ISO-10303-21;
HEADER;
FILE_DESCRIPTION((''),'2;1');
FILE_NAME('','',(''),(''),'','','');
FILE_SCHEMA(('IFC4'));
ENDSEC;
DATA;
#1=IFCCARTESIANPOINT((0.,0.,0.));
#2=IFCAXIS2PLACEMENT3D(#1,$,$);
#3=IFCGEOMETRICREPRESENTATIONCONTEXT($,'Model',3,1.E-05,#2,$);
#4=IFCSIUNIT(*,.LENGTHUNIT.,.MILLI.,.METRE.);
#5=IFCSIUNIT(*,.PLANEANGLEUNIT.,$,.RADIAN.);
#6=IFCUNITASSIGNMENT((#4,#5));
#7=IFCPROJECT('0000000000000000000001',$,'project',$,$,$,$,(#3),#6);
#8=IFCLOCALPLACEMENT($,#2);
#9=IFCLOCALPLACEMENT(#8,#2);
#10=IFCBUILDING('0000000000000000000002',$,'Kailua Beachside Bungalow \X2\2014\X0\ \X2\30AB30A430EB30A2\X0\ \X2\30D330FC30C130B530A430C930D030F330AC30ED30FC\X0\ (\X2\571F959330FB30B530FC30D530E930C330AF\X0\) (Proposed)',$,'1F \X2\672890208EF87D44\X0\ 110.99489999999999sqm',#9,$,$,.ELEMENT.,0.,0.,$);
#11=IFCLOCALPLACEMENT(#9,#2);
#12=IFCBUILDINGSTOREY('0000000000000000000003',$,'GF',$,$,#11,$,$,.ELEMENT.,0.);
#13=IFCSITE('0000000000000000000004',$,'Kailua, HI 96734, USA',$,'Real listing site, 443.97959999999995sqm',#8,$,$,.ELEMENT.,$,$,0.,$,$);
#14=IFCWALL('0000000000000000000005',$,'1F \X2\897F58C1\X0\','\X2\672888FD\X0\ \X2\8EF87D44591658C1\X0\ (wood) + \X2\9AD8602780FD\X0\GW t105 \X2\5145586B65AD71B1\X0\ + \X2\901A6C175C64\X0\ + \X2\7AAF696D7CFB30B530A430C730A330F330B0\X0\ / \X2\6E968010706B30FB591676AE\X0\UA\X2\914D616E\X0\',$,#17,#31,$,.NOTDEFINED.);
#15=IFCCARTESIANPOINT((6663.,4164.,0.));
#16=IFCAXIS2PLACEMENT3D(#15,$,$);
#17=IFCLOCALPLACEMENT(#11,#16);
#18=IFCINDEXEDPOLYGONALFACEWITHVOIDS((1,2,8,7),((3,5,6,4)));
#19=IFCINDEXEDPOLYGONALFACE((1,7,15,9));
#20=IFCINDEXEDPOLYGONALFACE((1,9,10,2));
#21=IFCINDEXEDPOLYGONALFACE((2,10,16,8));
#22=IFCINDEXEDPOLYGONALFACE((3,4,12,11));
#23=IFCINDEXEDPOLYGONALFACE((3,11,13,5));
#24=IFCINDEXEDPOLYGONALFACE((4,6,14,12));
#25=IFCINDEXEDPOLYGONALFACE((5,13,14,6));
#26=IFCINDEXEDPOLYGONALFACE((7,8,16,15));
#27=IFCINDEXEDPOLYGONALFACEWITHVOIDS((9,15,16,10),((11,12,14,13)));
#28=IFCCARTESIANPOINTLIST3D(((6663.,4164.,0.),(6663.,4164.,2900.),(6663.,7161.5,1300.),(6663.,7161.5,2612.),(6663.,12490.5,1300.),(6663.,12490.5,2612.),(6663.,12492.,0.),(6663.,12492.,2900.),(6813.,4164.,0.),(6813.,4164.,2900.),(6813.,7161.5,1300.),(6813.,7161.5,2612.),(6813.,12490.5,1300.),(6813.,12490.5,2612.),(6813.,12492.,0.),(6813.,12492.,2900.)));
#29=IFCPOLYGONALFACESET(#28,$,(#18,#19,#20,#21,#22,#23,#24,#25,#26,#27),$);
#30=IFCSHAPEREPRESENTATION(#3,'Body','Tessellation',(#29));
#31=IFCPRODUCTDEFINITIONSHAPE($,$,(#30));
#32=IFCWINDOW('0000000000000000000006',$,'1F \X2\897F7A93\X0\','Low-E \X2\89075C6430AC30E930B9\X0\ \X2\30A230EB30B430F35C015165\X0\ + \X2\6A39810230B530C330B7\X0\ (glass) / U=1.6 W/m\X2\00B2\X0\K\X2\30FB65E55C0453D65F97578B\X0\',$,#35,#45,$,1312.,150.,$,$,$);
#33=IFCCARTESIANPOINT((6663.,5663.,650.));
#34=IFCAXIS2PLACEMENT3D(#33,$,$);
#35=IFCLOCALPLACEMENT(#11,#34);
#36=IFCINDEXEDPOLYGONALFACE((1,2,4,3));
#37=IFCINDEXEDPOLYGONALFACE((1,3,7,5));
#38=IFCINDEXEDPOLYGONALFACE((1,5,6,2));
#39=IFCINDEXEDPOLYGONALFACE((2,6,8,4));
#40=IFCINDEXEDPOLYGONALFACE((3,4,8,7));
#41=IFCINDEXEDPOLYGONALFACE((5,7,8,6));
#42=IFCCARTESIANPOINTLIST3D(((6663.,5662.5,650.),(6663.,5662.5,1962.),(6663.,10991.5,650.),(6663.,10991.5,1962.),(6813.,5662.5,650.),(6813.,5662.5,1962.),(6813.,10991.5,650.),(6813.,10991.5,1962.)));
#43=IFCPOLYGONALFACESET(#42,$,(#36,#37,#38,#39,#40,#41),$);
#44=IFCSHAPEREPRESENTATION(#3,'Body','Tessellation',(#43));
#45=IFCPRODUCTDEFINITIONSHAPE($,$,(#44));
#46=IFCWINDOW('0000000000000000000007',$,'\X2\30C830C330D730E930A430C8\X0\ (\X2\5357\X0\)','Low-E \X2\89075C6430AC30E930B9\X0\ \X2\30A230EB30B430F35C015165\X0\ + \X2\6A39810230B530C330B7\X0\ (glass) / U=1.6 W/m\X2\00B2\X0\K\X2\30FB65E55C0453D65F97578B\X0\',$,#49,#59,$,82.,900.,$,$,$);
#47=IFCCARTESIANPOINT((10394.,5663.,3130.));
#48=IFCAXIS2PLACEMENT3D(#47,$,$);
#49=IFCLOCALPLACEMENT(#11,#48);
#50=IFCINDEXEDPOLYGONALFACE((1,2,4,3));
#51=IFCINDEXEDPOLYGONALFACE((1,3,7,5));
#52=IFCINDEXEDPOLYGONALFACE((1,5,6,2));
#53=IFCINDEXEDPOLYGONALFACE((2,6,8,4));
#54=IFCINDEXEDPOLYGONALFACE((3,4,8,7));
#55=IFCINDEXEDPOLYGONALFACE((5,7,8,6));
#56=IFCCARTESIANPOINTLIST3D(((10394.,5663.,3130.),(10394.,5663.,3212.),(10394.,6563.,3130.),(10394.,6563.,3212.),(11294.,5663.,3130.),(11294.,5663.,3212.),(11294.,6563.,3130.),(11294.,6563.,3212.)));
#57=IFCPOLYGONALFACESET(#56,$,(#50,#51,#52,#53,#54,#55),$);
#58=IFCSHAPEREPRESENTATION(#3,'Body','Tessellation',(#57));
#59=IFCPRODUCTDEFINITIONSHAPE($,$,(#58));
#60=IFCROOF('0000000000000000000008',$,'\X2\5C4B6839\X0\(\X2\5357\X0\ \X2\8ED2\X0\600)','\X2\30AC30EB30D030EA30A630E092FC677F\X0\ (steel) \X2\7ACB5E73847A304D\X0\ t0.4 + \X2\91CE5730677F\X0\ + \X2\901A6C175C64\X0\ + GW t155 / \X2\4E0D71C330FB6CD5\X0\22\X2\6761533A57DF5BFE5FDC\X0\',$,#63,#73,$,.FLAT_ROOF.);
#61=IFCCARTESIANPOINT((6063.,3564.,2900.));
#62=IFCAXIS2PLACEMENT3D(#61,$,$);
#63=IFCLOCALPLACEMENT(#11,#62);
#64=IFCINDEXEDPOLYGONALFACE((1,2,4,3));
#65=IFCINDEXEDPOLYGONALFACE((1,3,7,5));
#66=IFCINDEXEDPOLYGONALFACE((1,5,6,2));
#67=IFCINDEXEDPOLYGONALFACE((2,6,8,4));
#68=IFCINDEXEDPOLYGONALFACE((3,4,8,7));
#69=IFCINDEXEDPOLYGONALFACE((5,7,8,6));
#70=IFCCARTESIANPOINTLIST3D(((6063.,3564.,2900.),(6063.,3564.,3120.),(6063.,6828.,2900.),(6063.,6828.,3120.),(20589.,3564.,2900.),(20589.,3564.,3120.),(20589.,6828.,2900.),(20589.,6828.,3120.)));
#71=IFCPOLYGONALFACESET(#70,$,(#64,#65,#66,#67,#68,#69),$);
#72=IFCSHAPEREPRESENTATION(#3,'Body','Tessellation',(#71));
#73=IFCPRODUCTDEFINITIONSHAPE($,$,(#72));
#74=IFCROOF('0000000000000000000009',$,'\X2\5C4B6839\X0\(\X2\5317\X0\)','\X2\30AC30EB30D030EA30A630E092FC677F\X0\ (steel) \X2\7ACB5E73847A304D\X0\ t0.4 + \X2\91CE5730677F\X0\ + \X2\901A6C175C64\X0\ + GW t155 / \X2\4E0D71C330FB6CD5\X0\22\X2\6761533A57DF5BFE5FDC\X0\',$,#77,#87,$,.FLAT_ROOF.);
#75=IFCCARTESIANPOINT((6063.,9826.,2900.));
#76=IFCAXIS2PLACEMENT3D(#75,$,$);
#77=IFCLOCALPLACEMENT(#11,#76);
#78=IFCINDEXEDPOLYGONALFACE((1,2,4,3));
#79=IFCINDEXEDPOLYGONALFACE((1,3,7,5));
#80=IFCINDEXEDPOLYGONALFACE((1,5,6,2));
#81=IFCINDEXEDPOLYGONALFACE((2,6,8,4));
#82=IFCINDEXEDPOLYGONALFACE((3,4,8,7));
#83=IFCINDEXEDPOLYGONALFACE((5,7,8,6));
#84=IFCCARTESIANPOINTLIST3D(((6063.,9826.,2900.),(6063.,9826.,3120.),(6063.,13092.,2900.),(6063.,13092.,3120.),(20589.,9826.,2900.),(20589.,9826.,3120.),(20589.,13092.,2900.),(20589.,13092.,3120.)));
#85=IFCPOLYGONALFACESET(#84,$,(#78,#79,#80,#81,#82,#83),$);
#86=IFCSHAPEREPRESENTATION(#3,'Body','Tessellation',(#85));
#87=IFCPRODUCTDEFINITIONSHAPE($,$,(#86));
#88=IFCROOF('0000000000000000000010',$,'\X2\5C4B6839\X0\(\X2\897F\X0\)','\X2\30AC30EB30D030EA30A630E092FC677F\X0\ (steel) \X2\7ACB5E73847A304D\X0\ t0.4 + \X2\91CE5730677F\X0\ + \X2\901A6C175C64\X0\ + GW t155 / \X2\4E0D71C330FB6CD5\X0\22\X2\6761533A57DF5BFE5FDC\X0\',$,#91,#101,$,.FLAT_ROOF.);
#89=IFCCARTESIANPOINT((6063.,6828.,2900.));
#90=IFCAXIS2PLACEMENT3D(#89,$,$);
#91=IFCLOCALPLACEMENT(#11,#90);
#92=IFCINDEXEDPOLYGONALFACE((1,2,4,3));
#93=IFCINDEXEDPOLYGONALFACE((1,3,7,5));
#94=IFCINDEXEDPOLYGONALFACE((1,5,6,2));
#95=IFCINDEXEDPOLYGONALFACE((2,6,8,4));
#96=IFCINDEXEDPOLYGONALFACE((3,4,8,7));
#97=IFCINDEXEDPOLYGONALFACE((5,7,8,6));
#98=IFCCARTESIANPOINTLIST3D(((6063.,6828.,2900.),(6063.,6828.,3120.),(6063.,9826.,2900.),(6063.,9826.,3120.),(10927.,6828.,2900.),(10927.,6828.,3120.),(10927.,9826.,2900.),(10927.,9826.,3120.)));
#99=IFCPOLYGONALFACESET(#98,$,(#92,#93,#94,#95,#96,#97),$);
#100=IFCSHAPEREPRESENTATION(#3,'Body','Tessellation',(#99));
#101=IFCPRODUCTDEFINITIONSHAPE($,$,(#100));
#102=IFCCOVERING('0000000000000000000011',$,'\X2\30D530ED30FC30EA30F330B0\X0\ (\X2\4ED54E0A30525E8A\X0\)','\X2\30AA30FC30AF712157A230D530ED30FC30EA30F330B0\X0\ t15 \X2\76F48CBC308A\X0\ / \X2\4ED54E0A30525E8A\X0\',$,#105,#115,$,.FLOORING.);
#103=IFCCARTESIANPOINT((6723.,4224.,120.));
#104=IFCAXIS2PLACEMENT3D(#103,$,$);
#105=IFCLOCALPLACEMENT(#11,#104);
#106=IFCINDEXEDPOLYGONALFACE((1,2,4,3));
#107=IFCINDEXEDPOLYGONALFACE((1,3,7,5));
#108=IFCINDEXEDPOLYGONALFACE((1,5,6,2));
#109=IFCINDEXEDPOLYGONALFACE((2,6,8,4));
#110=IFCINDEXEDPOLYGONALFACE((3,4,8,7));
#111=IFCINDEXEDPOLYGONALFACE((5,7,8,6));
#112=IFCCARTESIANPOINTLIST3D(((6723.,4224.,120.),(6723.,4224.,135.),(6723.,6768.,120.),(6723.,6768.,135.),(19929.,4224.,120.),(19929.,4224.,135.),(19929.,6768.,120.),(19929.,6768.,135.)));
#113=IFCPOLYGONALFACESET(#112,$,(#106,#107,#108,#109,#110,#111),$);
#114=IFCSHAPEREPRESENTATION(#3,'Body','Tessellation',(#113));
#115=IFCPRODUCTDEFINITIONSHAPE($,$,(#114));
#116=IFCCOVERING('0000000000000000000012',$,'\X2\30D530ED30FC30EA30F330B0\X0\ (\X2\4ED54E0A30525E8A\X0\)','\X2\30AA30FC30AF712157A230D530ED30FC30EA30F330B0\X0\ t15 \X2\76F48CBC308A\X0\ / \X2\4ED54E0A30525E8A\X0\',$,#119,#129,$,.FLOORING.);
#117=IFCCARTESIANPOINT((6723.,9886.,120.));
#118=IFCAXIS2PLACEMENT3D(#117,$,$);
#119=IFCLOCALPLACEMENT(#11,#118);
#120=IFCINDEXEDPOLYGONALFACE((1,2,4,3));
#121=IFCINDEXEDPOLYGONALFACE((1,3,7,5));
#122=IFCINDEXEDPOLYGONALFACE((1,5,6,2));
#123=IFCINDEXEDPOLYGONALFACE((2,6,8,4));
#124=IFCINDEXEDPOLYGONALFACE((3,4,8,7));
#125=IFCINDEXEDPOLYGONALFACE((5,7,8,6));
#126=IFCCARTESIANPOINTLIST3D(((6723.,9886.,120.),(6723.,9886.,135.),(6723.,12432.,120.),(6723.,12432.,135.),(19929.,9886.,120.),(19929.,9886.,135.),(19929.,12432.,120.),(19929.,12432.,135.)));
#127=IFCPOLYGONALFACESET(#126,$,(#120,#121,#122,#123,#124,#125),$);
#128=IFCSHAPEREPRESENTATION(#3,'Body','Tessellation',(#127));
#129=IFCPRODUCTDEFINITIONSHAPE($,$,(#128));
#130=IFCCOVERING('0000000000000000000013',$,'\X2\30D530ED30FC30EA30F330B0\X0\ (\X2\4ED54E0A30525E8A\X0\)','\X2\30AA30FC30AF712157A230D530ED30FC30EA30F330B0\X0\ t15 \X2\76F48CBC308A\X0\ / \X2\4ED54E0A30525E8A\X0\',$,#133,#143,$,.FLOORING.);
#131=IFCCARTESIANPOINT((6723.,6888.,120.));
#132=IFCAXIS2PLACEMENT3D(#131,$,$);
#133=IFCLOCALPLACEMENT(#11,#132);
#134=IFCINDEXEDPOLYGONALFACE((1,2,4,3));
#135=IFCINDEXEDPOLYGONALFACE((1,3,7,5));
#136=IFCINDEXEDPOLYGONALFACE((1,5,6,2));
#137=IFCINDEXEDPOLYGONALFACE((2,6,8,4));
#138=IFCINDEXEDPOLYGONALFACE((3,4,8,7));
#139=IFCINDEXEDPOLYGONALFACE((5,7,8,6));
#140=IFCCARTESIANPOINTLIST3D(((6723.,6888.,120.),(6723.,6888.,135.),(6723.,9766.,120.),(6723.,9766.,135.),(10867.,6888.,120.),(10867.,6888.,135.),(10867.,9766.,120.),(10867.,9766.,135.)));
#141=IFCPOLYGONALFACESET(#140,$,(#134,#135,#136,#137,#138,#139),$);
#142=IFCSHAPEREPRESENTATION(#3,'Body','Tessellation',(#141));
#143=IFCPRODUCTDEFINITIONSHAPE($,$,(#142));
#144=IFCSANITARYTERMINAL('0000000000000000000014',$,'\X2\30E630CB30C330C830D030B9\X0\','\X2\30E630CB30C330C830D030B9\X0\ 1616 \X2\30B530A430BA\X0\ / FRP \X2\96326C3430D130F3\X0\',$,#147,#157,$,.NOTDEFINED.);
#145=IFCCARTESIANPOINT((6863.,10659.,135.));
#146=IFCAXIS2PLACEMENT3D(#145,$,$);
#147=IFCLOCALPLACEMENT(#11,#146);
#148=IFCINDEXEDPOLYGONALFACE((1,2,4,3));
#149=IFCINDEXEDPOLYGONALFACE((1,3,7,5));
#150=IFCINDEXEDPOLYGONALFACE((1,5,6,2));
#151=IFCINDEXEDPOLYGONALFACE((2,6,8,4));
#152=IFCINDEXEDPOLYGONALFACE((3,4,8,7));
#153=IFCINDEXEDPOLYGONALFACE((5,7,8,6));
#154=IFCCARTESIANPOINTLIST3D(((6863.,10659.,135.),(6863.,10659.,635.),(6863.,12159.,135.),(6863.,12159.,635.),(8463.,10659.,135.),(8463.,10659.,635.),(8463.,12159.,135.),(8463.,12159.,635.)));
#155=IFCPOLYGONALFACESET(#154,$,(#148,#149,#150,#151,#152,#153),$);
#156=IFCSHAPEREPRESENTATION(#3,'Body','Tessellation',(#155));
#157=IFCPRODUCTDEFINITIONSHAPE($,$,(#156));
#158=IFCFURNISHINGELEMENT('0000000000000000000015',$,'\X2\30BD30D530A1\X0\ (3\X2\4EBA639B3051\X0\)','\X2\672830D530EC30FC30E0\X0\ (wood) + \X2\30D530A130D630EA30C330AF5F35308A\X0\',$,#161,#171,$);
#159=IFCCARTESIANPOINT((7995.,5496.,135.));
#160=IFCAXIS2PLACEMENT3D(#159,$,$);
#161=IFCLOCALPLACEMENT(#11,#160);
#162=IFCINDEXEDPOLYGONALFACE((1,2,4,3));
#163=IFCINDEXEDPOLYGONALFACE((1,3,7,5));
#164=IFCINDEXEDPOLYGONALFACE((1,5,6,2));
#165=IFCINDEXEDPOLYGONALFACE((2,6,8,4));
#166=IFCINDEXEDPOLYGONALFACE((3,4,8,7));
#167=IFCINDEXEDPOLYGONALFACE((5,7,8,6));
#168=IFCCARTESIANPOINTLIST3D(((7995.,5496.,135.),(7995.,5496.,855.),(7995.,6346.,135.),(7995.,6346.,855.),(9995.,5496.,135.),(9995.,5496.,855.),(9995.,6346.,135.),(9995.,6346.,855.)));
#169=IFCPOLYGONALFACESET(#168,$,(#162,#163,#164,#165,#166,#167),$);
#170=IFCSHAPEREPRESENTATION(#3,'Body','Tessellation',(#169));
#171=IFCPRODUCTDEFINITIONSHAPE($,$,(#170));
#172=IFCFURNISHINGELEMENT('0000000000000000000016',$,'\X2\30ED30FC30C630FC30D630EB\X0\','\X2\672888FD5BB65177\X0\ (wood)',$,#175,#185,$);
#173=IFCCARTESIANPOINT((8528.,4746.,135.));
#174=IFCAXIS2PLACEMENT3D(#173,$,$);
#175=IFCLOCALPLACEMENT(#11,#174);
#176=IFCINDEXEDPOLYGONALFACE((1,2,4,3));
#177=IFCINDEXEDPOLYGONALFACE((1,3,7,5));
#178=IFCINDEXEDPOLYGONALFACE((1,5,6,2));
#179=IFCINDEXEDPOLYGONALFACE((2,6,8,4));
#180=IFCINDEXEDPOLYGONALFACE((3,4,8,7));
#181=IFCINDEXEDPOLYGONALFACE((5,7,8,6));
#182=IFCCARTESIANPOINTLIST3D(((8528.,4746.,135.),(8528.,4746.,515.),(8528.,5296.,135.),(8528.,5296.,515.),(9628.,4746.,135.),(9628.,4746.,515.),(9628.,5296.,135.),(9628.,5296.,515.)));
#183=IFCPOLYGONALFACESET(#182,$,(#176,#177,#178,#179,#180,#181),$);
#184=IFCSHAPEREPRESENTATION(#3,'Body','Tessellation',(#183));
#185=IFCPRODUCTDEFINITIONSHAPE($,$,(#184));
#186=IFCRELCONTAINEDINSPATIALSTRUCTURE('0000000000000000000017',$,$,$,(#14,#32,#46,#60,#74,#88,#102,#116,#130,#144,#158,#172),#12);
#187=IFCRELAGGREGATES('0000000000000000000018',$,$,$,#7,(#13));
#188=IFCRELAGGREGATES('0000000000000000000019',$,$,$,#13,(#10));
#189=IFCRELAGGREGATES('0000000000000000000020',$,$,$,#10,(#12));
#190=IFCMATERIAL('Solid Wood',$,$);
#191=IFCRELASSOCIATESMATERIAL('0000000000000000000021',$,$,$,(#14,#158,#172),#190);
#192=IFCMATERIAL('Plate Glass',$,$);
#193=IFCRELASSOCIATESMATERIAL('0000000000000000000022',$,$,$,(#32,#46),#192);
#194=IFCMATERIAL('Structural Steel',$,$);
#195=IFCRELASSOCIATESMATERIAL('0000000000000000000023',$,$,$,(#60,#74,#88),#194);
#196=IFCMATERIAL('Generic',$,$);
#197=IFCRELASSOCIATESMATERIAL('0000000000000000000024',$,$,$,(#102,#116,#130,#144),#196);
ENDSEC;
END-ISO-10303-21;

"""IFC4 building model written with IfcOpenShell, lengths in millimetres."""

from ifc_helpers import new_model, si_unit, frame, frame_2d, origin, place, context, project, spatial, rectangle, extrude, material, element, fill, save


model = new_model("IFC4")

# Units and contexts
model_context = context("Model", 3, precision=1e-05, world=origin())
ifc_project = project(units=[si_unit("LENGTHUNIT", "METRE", prefix="MILLI"), si_unit("PLANEANGLEUNIT", "RADIAN")], contexts=[model_context])

# Site, building, storey
site_placement = place(None, origin())
site = spatial("IfcSite", under=ifc_project, at=site_placement, Name="Kailua, HI 96734, USA", ObjectType="Real listing site, 443.97959999999995sqm", CompositionType="ELEMENT", RefElevation=0.0)
building_placement = place(site_placement, origin())
building = spatial("IfcBuilding", under=site, at=building_placement, Name="Kailua Beachside Bungalow — カイルア ビーチサイドバンガロー (土間・サーフラック) (Proposed)", ObjectType="1F 木造軸組 110.99489999999999sqm", CompositionType="ELEMENT", ElevationOfRefHeight=0.0, ElevationOfTerrain=0.0)
storey_placement = place(building_placement, origin())
storey = spatial("IfcBuildingStorey", under=building, at=storey_placement, Name="GF", CompositionType="ELEMENT", Elevation=0.0)

# Shared definitions
ifc_material_1 = material(Name="Solid Wood")

# Shared definitions
ifc_material_2 = material(Name="Plate Glass")

# Wall, opening, window
wall_1_placement = place(storey_placement, frame((6663.0, 4164.0, 0.0)))
wall_1 = element("IfcWall", 1, at=wall_1_placement, inside=storey, material=ifc_material_1, Name="1F 西壁", Description="木製 軸組外壁 (wood) + 高性能GW t105 充填断熱 + 通気層 + 窯業系サイディング / 準耐火・外皮UA配慮", PredefinedType="NOTDEFINED", context=model_context, shape_type="SweptSolid", body=[
    extrude(rectangle(XDim=150.0, YDim=8328.0, at=frame_2d((75.0, 4164.0))), frame((6663.0, 4164.0, 0.0)), (0.0, 0.0, 1.0), 2900.0),
])
opening_1_placement = place(storey_placement, frame((6663.0, 5663.0, 650.0)))
opening_1 = element("IfcOpeningElement", 2, at=opening_1_placement, cuts=wall_1, PredefinedType="NOTDEFINED", context=model_context, shape_type="SweptSolid", body=[
    extrude(rectangle(XDim=150.0, YDim=5329.0, at=frame_2d((75.0, 2664.0))), frame((6663.0, 5663.0, 650.0)), (0.0, 0.0, 1.0), 1312.0),
])
window_1_placement = place(storey_placement, frame((6663.0, 5663.0, 650.0)))
window_1 = element("IfcWindow", 3, at=window_1_placement, inside=storey, material=ifc_material_2, Name="1F 西窓", Description="Low-E 複層ガラス アルゴン封入 + 樹脂サッシ (glass) / U=1.6 W/m²K・日射取得型", OverallHeight=1312.0, OverallWidth=150.0, context=model_context, shape_type="SweptSolid", body=[
    extrude(rectangle(XDim=150.0, YDim=5329.0, at=frame_2d((75.0, 2664.0))), frame((6663.0, 5663.0, 650.0)), (0.0, 0.0, 1.0), 1312.0),
])
fill(opening_1, window_1)

# Window
window_2_placement = place(storey_placement, frame((10394.0, 5663.0, 3130.0)))
element("IfcWindow", 4, at=window_2_placement, inside=storey, material=ifc_material_2, Name="トップライト (南)", Description="Low-E 複層ガラス アルゴン封入 + 樹脂サッシ (glass) / U=1.6 W/m²K・日射取得型", OverallHeight=82.0, OverallWidth=900.0, context=model_context, shape_type="SweptSolid", body=[
    extrude(rectangle(XDim=900.0, YDim=900.0, at=frame_2d((450.0, 450.0))), frame((10394.0, 5663.0, 3130.0)), (0.0, 0.0, 1.0), 82.0),
])

# Roofs
ifc_material_3 = material(Name="Structural Steel")
roof_1_placement = place(storey_placement, frame((6063.0, 3564.0, 2900.0)))
element("IfcRoof", 5, at=roof_1_placement, inside=storey, material=ifc_material_3, Name="屋根(南 軒600)", Description="ガルバリウム鋼板 (steel) 立平葺き t0.4 + 野地板 + 通気層 + GW t155 / 不燃・法22条区域対応", PredefinedType="FLAT_ROOF", context=model_context, shape_type="SweptSolid", body=[
    extrude(rectangle(XDim=14526.0, YDim=3264.0, at=frame_2d((7263.0, 1632.0))), frame((6063.0, 3564.0, 2900.0)), (0.0, 0.0, 1.0), 220.0),
])
roof_2_placement = place(storey_placement, frame((6063.0, 9826.0, 2900.0)))
element("IfcRoof", 6, at=roof_2_placement, inside=storey, material=ifc_material_3, Name="屋根(北)", Description="ガルバリウム鋼板 (steel) 立平葺き t0.4 + 野地板 + 通気層 + GW t155 / 不燃・法22条区域対応", PredefinedType="FLAT_ROOF", context=model_context, shape_type="SweptSolid", body=[
    extrude(rectangle(XDim=14526.0, YDim=3266.0, at=frame_2d((7263.0, 1633.0))), frame((6063.0, 9826.0, 2900.0)), (0.0, 0.0, 1.0), 220.0),
])
roof_3_placement = place(storey_placement, frame((6063.0, 6828.0, 2900.0)))
element("IfcRoof", 7, at=roof_3_placement, inside=storey, material=ifc_material_3, Name="屋根(西)", Description="ガルバリウム鋼板 (steel) 立平葺き t0.4 + 野地板 + 通気層 + GW t155 / 不燃・法22条区域対応", PredefinedType="FLAT_ROOF", context=model_context, shape_type="SweptSolid", body=[
    extrude(rectangle(XDim=4864.0, YDim=2998.0, at=frame_2d((2432.0, 1499.0))), frame((6063.0, 6828.0, 2900.0)), (0.0, 0.0, 1.0), 220.0),
])

# Coverings
ifc_material_4 = material(Name="Generic")
covering_1_placement = place(storey_placement, frame((6723.0, 4224.0, 120.0)))
element("IfcCovering", 8, at=covering_1_placement, inside=storey, material=ifc_material_4, Name="フローリング (仕上げ床)", Description="オーク無垢フローリング t15 直貼り / 仕上げ床", PredefinedType="FLOORING", context=model_context, shape_type="SweptSolid", body=[
    extrude(rectangle(XDim=13206.0, YDim=2544.0, at=frame_2d((6603.0, 1272.0))), frame((6723.0, 4224.0, 120.0)), (0.0, 0.0, 1.0), 15.0),
])
covering_2_placement = place(storey_placement, frame((6723.0, 9886.0, 120.0)))
element("IfcCovering", 9, at=covering_2_placement, inside=storey, material=ifc_material_4, Name="フローリング (仕上げ床)", Description="オーク無垢フローリング t15 直貼り / 仕上げ床", PredefinedType="FLOORING", context=model_context, shape_type="SweptSolid", body=[
    extrude(rectangle(XDim=13206.0, YDim=2546.0, at=frame_2d((6603.0, 1273.0))), frame((6723.0, 9886.0, 120.0)), (0.0, 0.0, 1.0), 15.0),
])
covering_3_placement = place(storey_placement, frame((6723.0, 6888.0, 120.0)))
element("IfcCovering", 10, at=covering_3_placement, inside=storey, material=ifc_material_4, Name="フローリング (仕上げ床)", Description="オーク無垢フローリング t15 直貼り / 仕上げ床", PredefinedType="FLOORING", context=model_context, shape_type="SweptSolid", body=[
    extrude(rectangle(XDim=4144.0, YDim=2878.0, at=frame_2d((2072.0, 1439.0))), frame((6723.0, 6888.0, 120.0)), (0.0, 0.0, 1.0), 15.0),
])

# Sanitary terminal
sanitary_terminal_placement = place(storey_placement, frame((6863.0, 10659.0, 135.0)))
element("IfcSanitaryTerminal", 11, at=sanitary_terminal_placement, inside=storey, material=ifc_material_4, Name="ユニットバス", Description="ユニットバス 1616 サイズ / FRP 防水パン", PredefinedType="NOTDEFINED", context=model_context, shape_type="SweptSolid", body=[
    extrude(rectangle(XDim=1600.0, YDim=1500.0, at=frame_2d((800.0, 750.0))), frame((6863.0, 10659.0, 135.0)), (0.0, 0.0, 1.0), 500.0),
])

# Furnishing elements
furnishing_1_placement = place(storey_placement, frame((7995.0, 5496.0, 135.0)))
element("IfcFurnishingElement", 12, at=furnishing_1_placement, inside=storey, material=ifc_material_1, Name="ソファ (3人掛け)", Description="木フレーム (wood) + ファブリック張り", context=model_context, shape_type="SweptSolid", body=[
    extrude(rectangle(XDim=2000.0, YDim=850.0, at=frame_2d((1000.0, 425.0))), frame((7995.0, 5496.0, 135.0)), (0.0, 0.0, 1.0), 720.0),
])
furnishing_2_placement = place(storey_placement, frame((8528.0, 4746.0, 135.0)))
element("IfcFurnishingElement", 13, at=furnishing_2_placement, inside=storey, material=ifc_material_1, Name="ローテーブル", Description="木製家具 (wood)", context=model_context, shape_type="SweptSolid", body=[
    extrude(rectangle(XDim=1100.0, YDim=550.0, at=frame_2d((550.0, 275.0))), frame((8528.0, 4746.0, 135.0)), (0.0, 0.0, 1.0), 380.0),
])

save(model, "model.ifc")
